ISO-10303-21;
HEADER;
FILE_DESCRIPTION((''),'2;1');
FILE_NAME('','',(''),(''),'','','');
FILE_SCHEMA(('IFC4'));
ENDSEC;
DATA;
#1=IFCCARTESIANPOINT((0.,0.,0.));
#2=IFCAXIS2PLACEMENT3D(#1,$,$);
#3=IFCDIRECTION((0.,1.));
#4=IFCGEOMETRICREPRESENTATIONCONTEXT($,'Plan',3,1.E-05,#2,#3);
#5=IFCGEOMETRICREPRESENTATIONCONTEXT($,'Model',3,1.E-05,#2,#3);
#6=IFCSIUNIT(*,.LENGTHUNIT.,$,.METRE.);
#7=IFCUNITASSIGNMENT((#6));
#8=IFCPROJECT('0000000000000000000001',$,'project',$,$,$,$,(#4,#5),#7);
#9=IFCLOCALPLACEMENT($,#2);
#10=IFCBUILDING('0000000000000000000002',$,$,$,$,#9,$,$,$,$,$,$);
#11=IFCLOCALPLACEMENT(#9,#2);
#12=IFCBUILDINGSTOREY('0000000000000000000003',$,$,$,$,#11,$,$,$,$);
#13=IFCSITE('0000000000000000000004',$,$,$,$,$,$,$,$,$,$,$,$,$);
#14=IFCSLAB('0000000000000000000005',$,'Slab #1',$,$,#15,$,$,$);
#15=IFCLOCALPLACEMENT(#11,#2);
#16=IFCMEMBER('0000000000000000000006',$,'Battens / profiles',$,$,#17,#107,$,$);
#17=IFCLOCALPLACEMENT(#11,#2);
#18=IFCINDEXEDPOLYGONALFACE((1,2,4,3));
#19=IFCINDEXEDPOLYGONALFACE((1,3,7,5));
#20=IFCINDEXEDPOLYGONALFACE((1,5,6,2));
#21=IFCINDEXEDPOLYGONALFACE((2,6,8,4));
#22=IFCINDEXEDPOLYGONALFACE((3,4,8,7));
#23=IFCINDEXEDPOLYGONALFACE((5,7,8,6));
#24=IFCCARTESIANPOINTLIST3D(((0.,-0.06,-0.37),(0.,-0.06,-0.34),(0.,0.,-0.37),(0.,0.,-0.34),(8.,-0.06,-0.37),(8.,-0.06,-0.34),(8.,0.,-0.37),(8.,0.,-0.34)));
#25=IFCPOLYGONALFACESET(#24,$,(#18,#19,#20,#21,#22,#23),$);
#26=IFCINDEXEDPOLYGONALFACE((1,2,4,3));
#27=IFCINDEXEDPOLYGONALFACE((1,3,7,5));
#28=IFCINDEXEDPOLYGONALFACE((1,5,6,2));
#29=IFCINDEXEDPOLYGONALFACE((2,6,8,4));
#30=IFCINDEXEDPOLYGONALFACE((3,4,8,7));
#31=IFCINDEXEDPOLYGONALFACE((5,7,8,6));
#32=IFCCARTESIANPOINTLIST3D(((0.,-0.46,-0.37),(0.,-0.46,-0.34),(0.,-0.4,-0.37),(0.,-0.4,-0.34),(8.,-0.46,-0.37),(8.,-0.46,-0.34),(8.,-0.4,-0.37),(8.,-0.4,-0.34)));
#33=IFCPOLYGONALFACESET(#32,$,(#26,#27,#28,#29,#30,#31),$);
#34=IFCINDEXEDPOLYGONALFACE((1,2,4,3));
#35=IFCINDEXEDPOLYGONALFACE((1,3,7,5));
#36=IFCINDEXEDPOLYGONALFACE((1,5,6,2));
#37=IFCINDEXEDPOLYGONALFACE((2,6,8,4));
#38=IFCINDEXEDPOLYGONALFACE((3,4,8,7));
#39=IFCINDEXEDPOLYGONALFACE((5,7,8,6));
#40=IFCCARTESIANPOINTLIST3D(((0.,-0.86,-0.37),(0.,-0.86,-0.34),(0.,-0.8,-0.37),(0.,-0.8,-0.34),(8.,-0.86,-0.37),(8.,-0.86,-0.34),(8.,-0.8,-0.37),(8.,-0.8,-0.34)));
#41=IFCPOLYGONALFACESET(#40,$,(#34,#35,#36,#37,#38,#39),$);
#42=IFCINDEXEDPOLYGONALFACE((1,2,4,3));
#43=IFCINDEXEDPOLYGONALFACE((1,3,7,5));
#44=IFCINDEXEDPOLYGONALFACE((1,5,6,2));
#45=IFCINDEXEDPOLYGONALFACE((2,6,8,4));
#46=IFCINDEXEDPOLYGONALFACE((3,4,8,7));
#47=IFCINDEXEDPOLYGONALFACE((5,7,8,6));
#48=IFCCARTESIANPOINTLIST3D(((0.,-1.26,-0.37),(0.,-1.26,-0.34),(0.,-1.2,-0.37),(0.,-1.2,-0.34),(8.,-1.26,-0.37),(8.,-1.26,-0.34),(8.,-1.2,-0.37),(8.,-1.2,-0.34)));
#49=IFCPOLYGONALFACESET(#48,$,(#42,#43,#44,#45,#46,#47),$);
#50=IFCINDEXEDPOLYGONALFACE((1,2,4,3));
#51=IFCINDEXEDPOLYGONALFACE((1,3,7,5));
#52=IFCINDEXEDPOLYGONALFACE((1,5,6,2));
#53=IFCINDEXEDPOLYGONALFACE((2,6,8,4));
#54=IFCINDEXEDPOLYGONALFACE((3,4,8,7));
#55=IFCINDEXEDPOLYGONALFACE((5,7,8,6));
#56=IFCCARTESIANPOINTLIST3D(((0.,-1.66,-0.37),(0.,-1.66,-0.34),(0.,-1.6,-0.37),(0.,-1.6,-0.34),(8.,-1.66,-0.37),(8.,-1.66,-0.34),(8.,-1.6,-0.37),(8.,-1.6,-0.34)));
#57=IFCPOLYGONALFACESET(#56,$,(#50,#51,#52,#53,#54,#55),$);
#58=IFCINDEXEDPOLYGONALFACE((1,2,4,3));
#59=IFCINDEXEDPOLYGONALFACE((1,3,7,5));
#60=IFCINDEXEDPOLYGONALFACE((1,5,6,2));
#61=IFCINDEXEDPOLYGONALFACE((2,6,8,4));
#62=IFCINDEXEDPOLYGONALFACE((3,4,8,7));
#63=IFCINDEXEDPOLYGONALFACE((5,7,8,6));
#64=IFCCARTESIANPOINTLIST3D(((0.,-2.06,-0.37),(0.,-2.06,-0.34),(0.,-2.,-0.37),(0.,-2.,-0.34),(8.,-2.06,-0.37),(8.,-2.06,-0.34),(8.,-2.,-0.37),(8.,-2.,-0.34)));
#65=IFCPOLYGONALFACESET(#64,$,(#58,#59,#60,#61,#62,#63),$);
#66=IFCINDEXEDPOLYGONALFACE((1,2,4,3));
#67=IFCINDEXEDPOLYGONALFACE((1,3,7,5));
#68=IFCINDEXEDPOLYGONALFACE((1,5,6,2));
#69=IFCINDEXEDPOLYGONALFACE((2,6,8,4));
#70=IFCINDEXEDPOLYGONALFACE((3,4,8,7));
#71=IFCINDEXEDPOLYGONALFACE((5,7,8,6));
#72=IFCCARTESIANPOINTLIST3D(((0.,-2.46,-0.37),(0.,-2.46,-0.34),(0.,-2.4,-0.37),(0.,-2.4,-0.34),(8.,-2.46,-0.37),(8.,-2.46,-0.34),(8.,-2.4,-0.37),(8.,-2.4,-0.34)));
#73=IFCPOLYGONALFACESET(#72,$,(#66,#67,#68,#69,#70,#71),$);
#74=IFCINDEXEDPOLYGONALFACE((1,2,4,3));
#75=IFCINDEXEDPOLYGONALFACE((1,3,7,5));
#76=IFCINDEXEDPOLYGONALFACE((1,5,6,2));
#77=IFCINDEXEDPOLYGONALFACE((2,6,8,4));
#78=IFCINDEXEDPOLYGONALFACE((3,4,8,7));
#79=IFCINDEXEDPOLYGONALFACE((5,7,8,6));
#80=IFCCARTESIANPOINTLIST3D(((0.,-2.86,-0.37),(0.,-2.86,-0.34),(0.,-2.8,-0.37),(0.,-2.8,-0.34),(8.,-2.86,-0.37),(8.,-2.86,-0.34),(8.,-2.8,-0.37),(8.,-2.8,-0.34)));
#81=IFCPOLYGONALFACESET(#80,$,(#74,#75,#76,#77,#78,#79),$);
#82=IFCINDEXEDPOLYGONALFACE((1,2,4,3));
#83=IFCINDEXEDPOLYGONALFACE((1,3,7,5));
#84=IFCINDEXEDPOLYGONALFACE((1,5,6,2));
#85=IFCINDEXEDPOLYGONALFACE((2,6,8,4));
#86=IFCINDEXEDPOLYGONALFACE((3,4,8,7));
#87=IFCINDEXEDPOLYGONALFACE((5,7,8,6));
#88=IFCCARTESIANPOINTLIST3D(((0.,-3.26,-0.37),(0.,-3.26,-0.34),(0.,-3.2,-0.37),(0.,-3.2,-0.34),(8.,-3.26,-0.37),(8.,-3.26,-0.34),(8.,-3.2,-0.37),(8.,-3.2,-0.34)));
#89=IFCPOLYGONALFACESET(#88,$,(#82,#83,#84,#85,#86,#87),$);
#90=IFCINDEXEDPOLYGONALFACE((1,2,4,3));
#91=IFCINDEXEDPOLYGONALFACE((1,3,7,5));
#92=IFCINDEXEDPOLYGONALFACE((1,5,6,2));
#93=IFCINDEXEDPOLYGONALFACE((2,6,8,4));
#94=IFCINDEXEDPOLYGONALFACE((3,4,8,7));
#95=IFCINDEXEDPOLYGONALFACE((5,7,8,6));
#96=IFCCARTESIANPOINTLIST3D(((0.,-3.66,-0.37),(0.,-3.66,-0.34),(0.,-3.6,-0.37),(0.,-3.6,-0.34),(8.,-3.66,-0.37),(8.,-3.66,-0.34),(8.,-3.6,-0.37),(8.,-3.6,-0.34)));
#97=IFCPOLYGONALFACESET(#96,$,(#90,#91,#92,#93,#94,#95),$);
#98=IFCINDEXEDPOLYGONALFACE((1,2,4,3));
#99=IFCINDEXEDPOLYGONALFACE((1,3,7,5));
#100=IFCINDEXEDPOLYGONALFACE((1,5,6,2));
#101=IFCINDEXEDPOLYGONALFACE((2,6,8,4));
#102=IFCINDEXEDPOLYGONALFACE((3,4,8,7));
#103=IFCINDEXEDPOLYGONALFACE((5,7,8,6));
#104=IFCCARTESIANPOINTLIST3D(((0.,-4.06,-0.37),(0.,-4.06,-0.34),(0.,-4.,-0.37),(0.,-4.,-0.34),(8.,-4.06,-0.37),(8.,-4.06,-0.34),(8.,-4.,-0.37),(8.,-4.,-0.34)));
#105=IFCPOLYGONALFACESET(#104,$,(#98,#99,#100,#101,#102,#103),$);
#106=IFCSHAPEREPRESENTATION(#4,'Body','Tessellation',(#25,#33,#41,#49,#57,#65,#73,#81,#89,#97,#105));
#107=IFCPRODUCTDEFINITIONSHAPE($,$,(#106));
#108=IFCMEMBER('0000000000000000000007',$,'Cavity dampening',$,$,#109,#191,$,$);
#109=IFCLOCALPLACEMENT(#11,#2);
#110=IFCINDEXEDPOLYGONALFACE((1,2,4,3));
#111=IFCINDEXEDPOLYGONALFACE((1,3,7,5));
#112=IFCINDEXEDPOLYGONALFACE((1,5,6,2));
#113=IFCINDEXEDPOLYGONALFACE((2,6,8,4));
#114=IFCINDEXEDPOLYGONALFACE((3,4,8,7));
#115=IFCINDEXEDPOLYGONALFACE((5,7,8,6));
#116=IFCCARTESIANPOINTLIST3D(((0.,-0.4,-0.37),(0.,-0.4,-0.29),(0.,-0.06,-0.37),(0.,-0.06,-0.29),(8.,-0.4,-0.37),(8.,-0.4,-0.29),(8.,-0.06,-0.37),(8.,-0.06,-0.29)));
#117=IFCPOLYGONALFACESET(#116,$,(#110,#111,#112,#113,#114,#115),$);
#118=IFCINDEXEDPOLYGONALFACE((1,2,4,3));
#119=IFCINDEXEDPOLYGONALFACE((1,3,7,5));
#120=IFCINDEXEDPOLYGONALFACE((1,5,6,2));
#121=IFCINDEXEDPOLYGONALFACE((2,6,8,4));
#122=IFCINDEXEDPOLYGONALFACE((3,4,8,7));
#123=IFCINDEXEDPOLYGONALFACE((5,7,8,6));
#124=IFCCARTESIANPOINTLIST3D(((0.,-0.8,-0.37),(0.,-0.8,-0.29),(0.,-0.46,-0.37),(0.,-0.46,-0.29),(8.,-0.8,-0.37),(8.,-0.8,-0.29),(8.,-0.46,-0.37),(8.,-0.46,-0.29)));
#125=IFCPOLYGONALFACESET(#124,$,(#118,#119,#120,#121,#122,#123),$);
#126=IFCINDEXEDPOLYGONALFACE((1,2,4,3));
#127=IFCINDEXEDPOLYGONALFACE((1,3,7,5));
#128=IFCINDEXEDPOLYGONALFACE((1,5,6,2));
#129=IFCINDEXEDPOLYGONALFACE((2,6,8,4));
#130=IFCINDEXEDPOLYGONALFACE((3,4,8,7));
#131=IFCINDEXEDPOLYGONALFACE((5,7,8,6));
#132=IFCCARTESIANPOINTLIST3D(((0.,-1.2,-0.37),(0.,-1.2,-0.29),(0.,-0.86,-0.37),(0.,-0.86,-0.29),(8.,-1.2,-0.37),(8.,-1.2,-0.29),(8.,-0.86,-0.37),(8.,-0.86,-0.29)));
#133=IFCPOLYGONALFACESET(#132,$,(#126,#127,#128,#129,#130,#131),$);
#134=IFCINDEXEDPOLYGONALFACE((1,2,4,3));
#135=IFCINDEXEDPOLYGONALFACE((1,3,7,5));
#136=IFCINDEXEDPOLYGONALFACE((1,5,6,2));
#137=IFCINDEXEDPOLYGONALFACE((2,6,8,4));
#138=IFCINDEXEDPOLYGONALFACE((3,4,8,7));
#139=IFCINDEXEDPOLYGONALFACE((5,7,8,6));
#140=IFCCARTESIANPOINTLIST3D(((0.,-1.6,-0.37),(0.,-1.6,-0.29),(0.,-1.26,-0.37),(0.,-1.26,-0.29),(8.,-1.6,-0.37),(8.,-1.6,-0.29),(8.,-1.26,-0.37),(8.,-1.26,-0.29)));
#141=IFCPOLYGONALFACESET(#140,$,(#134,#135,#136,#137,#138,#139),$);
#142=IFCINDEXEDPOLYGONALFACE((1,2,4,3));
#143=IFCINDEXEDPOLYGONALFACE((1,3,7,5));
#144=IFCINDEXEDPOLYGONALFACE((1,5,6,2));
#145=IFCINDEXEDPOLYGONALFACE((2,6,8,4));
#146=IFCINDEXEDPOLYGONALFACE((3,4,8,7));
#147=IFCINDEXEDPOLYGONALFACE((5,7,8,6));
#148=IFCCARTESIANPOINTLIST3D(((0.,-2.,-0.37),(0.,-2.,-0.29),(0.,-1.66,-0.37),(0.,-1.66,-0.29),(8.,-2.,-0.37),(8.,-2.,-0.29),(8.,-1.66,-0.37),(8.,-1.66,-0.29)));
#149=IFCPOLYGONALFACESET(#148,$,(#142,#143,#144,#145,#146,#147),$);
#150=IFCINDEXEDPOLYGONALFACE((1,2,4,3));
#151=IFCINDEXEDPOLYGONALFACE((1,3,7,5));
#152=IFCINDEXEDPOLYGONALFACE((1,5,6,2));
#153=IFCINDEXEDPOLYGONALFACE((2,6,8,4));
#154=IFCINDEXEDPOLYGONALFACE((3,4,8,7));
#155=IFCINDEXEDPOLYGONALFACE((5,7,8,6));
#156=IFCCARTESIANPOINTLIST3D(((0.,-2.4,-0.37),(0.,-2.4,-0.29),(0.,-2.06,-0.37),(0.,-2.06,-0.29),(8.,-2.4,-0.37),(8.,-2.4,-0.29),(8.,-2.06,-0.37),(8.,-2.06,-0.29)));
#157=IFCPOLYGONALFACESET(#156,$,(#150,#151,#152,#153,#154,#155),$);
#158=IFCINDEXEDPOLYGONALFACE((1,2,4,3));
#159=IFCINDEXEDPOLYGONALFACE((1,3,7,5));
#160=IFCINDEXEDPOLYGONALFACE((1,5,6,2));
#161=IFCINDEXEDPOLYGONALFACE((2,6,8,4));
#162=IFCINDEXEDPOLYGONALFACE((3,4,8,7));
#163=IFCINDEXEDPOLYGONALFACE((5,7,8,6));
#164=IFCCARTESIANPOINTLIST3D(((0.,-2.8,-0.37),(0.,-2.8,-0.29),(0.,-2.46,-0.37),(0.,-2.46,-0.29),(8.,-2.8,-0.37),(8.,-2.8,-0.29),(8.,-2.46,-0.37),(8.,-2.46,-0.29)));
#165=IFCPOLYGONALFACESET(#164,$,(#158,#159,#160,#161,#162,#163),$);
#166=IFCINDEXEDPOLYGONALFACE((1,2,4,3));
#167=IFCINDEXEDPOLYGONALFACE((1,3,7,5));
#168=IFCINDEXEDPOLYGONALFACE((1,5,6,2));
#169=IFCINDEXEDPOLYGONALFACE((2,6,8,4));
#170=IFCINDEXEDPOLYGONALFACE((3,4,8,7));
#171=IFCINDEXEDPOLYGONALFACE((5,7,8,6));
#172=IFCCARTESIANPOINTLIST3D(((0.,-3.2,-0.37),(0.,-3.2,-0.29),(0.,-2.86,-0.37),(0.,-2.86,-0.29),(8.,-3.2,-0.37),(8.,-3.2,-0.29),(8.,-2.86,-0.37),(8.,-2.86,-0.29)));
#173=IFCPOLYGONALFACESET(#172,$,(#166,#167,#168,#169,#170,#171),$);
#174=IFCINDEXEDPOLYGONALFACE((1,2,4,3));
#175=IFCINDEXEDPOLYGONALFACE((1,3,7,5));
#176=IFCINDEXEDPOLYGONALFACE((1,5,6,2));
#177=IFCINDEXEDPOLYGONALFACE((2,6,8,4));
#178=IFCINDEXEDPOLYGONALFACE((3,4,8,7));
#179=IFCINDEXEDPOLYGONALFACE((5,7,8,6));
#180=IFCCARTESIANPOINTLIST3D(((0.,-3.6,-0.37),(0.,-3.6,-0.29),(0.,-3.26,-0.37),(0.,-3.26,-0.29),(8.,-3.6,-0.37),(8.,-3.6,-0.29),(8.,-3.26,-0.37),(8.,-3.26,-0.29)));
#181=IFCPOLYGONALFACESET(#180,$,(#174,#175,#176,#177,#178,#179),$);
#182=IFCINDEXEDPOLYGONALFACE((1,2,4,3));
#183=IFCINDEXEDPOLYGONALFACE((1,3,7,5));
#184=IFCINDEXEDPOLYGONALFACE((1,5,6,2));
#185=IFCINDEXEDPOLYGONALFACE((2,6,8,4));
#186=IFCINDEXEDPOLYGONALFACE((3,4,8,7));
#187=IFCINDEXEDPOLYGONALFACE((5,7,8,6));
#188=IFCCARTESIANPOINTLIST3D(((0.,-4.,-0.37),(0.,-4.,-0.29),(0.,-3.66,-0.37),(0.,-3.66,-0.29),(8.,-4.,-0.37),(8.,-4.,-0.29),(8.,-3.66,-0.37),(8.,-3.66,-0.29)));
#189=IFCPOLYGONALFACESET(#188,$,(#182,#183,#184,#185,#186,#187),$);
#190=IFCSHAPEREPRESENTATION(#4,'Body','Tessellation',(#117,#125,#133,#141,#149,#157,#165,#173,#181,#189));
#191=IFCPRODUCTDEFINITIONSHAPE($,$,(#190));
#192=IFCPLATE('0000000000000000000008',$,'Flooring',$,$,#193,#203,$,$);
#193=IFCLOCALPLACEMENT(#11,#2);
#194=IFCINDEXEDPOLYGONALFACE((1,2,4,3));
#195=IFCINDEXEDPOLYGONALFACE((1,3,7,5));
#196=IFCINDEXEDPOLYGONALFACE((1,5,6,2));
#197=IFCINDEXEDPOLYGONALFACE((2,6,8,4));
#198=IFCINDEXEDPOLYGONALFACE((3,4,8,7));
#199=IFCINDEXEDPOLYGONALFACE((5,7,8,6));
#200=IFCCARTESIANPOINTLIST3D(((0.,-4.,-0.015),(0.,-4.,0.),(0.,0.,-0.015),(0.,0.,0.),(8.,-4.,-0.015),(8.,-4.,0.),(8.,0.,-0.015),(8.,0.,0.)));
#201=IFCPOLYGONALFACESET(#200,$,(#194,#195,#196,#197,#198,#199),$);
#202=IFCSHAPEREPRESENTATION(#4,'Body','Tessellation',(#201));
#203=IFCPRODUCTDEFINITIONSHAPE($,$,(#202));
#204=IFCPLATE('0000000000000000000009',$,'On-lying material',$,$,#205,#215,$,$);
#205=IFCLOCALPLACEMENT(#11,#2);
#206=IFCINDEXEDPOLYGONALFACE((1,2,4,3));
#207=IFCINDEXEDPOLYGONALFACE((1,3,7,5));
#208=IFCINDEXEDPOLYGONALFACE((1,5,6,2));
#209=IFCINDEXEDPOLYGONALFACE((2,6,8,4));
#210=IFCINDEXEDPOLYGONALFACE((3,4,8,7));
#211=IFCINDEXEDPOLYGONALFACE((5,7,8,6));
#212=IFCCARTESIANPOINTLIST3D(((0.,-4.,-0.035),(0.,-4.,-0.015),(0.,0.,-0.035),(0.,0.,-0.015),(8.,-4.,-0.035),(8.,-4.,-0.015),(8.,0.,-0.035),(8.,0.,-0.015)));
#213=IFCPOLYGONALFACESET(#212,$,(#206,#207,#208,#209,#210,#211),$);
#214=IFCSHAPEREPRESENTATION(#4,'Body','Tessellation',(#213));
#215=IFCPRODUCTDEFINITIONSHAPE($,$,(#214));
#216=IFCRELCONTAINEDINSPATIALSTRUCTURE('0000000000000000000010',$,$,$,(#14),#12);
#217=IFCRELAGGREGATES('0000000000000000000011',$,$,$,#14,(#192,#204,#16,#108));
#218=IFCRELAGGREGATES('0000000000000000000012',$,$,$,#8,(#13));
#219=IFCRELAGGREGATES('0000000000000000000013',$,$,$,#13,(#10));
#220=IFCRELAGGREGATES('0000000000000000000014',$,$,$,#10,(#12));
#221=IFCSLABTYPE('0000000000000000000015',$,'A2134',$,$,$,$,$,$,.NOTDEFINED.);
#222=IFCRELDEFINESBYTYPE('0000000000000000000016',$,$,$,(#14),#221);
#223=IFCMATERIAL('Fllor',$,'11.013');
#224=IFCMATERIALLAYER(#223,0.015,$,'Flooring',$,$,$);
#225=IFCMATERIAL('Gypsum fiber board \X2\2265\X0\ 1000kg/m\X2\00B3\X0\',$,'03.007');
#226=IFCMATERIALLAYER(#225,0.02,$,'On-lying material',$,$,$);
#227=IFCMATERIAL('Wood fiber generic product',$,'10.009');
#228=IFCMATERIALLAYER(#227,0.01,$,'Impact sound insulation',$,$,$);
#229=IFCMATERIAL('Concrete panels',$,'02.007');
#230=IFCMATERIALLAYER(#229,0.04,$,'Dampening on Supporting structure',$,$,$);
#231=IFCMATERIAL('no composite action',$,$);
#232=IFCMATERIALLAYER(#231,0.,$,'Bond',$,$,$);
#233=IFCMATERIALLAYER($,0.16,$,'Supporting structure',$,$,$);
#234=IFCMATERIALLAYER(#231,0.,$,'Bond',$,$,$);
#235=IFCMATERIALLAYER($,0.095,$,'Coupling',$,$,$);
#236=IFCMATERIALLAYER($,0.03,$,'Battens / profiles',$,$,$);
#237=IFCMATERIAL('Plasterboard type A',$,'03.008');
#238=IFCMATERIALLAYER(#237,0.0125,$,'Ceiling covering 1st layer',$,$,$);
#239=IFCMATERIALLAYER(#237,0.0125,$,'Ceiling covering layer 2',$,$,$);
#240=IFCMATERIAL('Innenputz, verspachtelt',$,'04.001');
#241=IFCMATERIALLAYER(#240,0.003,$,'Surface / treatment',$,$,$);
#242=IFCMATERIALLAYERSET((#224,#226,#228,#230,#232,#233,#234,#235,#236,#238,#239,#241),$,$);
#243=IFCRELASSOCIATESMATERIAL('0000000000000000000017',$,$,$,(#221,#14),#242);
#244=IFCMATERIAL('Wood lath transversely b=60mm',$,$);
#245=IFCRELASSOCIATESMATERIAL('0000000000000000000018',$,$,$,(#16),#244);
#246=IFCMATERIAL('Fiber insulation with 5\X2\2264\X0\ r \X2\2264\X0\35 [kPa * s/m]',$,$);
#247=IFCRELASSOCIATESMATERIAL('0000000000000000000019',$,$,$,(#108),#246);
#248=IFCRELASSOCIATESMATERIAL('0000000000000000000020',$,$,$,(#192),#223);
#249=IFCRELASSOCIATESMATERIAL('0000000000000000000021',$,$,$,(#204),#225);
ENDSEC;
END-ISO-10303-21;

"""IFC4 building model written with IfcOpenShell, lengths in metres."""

from ifc_helpers import new_model, si_unit, direction, frame, frame_2d, origin, origin_with_axes, place, context, project, spatial, rectangle, extrude, material, layer, layer_set, type_object, element, aggregate, save


model = new_model("IFC4")

# Units and contexts
plan_context = context("Plan", 3, precision=1e-05, world=origin(), true_north=direction((0.0, 1.0)))
model_context = context("Model", 3, precision=1e-05, world=origin(), true_north=direction((0.0, 1.0)))
ifc_project = project(units=[si_unit("LENGTHUNIT", "METRE")], contexts=[plan_context, model_context])

# Site, building, storey
site = spatial("IfcSite", under=ifc_project)
building_placement = place(None, origin())
building = spatial("IfcBuilding", under=site, at=building_placement)
storey_placement = place(building_placement, origin())
storey = spatial("IfcBuildingStorey", under=building, at=storey_placement)

# Slab, members, plates
ifc_material_1 = material(Name="Fllor", Category="11.013")
ifc_layer_1 = layer(ifc_material_1, 0.015, Name="Flooring")
ifc_material_2 = material(Name="Gypsum fiber board ≥ 1000kg/m³", Category="03.007")
ifc_layer_2 = layer(ifc_material_2, 0.02, Name="On-lying material")
ifc_material_3 = material(Name="Wood fiber generic product", Category="10.009")
ifc_layer_3 = layer(ifc_material_3, 0.01, Name="Impact sound insulation")
ifc_material_4 = material(Name="Concrete panels", Category="02.007")
ifc_layer_4 = layer(ifc_material_4, 0.04, Name="Dampening on Supporting structure")
ifc_material_5 = material(Name="no composite action")
ifc_layer_5 = layer(ifc_material_5, 0.0, Name="Bond")
ifc_layer_6 = layer(None, 0.16, Name="Supporting structure")
ifc_layer_7 = layer(ifc_material_5, 0.0, Name="Bond")
ifc_layer_8 = layer(None, 0.095, Name="Coupling")
ifc_layer_9 = layer(None, 0.03, Name="Battens / profiles")
ifc_material_6 = material(Name="Plasterboard type A", Category="03.008")
ifc_layer_10 = layer(ifc_material_6, 0.0125, Name="Ceiling covering 1st layer")
ifc_layer_11 = layer(ifc_material_6, 0.0125, Name="Ceiling covering layer 2")
ifc_material_7 = material(Name="Innenputz, verspachtelt", Category="04.001")
ifc_layer_12 = layer(ifc_material_7, 0.003, Name="Surface / treatment")
ifc_layer_set = layer_set([ifc_layer_1, ifc_layer_2, ifc_layer_3, ifc_layer_4, ifc_layer_5, ifc_layer_6, ifc_layer_7, ifc_layer_8, ifc_layer_9, ifc_layer_10, ifc_layer_11, ifc_layer_12])
slab_type = type_object("IfcSlabType", Name="A2134", PredefinedType="NOTDEFINED", material=ifc_layer_set)
slab_placement = place(None, frame((0.0, 0.0, 0.0), z_axis=(0.0, 0.0, -1.0), x_axis=(1.0, 0.0, 0.0)))
slab = element("IfcSlab", 1, at=slab_placement, inside=storey, type_object=slab_type, material=ifc_layer_set, Name="Slab #1")
ifc_material_8 = material(Name="Wood lath transversely b=60mm")
member_1_placement = place(slab_placement, origin())
member_1 = element("IfcMember", 2, at=member_1_placement, material=ifc_material_8, Name="Battens / profiles", context=plan_context, shape_type="SweptSolid", body=[
    extrude(rectangle(XDim=0.06, YDim=0.03, at=frame_2d((0.03, 0.015), x_axis=(1.0, 0.0))), frame((0.0, 0.0, 0.34), z_axis=(1.0, 0.0, 0.0), x_axis=(0.0, 1.0, 0.0)), (0.0, 0.0, 1.0), 8.0),
    extrude(rectangle(XDim=0.06, YDim=0.03, at=frame_2d((0.03, 0.015), x_axis=(1.0, 0.0))), frame((0.0, 0.4, 0.34), z_axis=(1.0, 0.0, 0.0), x_axis=(0.0, 1.0, 0.0)), (0.0, 0.0, 1.0), 8.0),
    extrude(rectangle(XDim=0.06, YDim=0.03, at=frame_2d((0.03, 0.015), x_axis=(1.0, 0.0))), frame((0.0, 0.8, 0.34), z_axis=(1.0, 0.0, 0.0), x_axis=(0.0, 1.0, 0.0)), (0.0, 0.0, 1.0), 8.0),
    extrude(rectangle(XDim=0.06, YDim=0.03, at=frame_2d((0.03, 0.015), x_axis=(1.0, 0.0))), frame((0.0, 1.2, 0.34), z_axis=(1.0, 0.0, 0.0), x_axis=(0.0, 1.0, 0.0)), (0.0, 0.0, 1.0), 8.0),
    extrude(rectangle(XDim=0.06, YDim=0.03, at=frame_2d((0.03, 0.015), x_axis=(1.0, 0.0))), frame((0.0, 1.6, 0.34), z_axis=(1.0, 0.0, 0.0), x_axis=(0.0, 1.0, 0.0)), (0.0, 0.0, 1.0), 8.0),
    extrude(rectangle(XDim=0.06, YDim=0.03, at=frame_2d((0.03, 0.015), x_axis=(1.0, 0.0))), frame((0.0, 2.0, 0.34), z_axis=(1.0, 0.0, 0.0), x_axis=(0.0, 1.0, 0.0)), (0.0, 0.0, 1.0), 8.0),
    extrude(rectangle(XDim=0.06, YDim=0.03, at=frame_2d((0.03, 0.015), x_axis=(1.0, 0.0))), frame((0.0, 2.4, 0.34), z_axis=(1.0, 0.0, 0.0), x_axis=(0.0, 1.0, 0.0)), (0.0, 0.0, 1.0), 8.0),
    extrude(rectangle(XDim=0.06, YDim=0.03, at=frame_2d((0.03, 0.015), x_axis=(1.0, 0.0))), frame((0.0, 2.8, 0.34), z_axis=(1.0, 0.0, 0.0), x_axis=(0.0, 1.0, 0.0)), (0.0, 0.0, 1.0), 8.0),
    extrude(rectangle(XDim=0.06, YDim=0.03, at=frame_2d((0.03, 0.015), x_axis=(1.0, 0.0))), frame((0.0, 3.2, 0.34), z_axis=(1.0, 0.0, 0.0), x_axis=(0.0, 1.0, 0.0)), (0.0, 0.0, 1.0), 8.0),
    extrude(rectangle(XDim=0.06, YDim=0.03, at=frame_2d((0.03, 0.015), x_axis=(1.0, 0.0))), frame((0.0, 3.6, 0.34), z_axis=(1.0, 0.0, 0.0), x_axis=(0.0, 1.0, 0.0)), (0.0, 0.0, 1.0), 8.0),
    extrude(rectangle(XDim=0.06, YDim=0.03, at=frame_2d((0.03, 0.015), x_axis=(1.0, 0.0))), frame((0.0, 4.0, 0.34), z_axis=(1.0, 0.0, 0.0), x_axis=(0.0, 1.0, 0.0)), (0.0, 0.0, 1.0), 8.0),
])
ifc_material_9 = material(Name="Fiber insulation with 5≤ r ≤35 [kPa * s/m]")
member_2_placement = place(slab_placement, origin())
member_2 = element("IfcMember", 3, at=member_2_placement, material=ifc_material_9, Name="Cavity dampening", context=plan_context, shape_type="SweptSolid", body=[
    extrude(rectangle(XDim=0.34, YDim=0.08, at=frame_2d((0.17, 0.04), x_axis=(1.0, 0.0))), frame((0.0, 0.06, 0.29), z_axis=(1.0, 0.0, 0.0), x_axis=(0.0, 1.0, 0.0)), (0.0, 0.0, 1.0), 8.0),
    extrude(rectangle(XDim=0.34, YDim=0.08, at=frame_2d((0.17, 0.04), x_axis=(1.0, 0.0))), frame((0.0, 0.46, 0.29), z_axis=(1.0, 0.0, 0.0), x_axis=(0.0, 1.0, 0.0)), (0.0, 0.0, 1.0), 8.0),
    extrude(rectangle(XDim=0.34, YDim=0.08, at=frame_2d((0.17, 0.04), x_axis=(1.0, 0.0))), frame((0.0, 0.86, 0.29), z_axis=(1.0, 0.0, 0.0), x_axis=(0.0, 1.0, 0.0)), (0.0, 0.0, 1.0), 8.0),
    extrude(rectangle(XDim=0.34, YDim=0.08, at=frame_2d((0.17, 0.04), x_axis=(1.0, 0.0))), frame((0.0, 1.26, 0.29), z_axis=(1.0, 0.0, 0.0), x_axis=(0.0, 1.0, 0.0)), (0.0, 0.0, 1.0), 8.0),
    extrude(rectangle(XDim=0.34, YDim=0.08, at=frame_2d((0.17, 0.04), x_axis=(1.0, 0.0))), frame((0.0, 1.66, 0.29), z_axis=(1.0, 0.0, 0.0), x_axis=(0.0, 1.0, 0.0)), (0.0, 0.0, 1.0), 8.0),
    extrude(rectangle(XDim=0.34, YDim=0.08, at=frame_2d((0.17, 0.04), x_axis=(1.0, 0.0))), frame((0.0, 2.06, 0.29), z_axis=(1.0, 0.0, 0.0), x_axis=(0.0, 1.0, 0.0)), (0.0, 0.0, 1.0), 8.0),
    extrude(rectangle(XDim=0.34, YDim=0.08, at=frame_2d((0.17, 0.04), x_axis=(1.0, 0.0))), frame((0.0, 2.46, 0.29), z_axis=(1.0, 0.0, 0.0), x_axis=(0.0, 1.0, 0.0)), (0.0, 0.0, 1.0), 8.0),
    extrude(rectangle(XDim=0.34, YDim=0.08, at=frame_2d((0.17, 0.04), x_axis=(1.0, 0.0))), frame((0.0, 2.86, 0.29), z_axis=(1.0, 0.0, 0.0), x_axis=(0.0, 1.0, 0.0)), (0.0, 0.0, 1.0), 8.0),
    extrude(rectangle(XDim=0.34, YDim=0.08, at=frame_2d((0.17, 0.04), x_axis=(1.0, 0.0))), frame((0.0, 3.26, 0.29), z_axis=(1.0, 0.0, 0.0), x_axis=(0.0, 1.0, 0.0)), (0.0, 0.0, 1.0), 8.0),
    extrude(rectangle(XDim=0.34, YDim=0.08, at=frame_2d((0.17, 0.04), x_axis=(1.0, 0.0))), frame((0.0, 3.66, 0.29), z_axis=(1.0, 0.0, 0.0), x_axis=(0.0, 1.0, 0.0)), (0.0, 0.0, 1.0), 8.0),
])
plate_1_placement = place(slab_placement, origin())
plate_1 = element("IfcPlate", 4, at=plate_1_placement, material=ifc_material_1, Name="Flooring", context=plan_context, shape_type="SweptSolid", body=[
    extrude(rectangle(XDim=8.0, YDim=4.0, at=frame_2d((4.0, 2.0), x_axis=(1.0, 0.0))), origin_with_axes(), (0.0, 0.0, 1.0), 0.015),
])
plate_2_placement = place(slab_placement, origin())
plate_2 = element("IfcPlate", 5, at=plate_2_placement, material=ifc_material_2, Name="On-lying material", context=plan_context, shape_type="SweptSolid", body=[
    extrude(rectangle(XDim=8.0, YDim=4.0, at=frame_2d((4.0, 2.0), x_axis=(1.0, 0.0))), frame((0.0, 0.0, 0.015), z_axis=(0.0, 0.0, 1.0), x_axis=(1.0, 0.0, 0.0)), (0.0, 0.0, 1.0), 0.02),
])
aggregate(slab, [plate_1, plate_2, member_1, member_2])

save(model, "model.ifc")
